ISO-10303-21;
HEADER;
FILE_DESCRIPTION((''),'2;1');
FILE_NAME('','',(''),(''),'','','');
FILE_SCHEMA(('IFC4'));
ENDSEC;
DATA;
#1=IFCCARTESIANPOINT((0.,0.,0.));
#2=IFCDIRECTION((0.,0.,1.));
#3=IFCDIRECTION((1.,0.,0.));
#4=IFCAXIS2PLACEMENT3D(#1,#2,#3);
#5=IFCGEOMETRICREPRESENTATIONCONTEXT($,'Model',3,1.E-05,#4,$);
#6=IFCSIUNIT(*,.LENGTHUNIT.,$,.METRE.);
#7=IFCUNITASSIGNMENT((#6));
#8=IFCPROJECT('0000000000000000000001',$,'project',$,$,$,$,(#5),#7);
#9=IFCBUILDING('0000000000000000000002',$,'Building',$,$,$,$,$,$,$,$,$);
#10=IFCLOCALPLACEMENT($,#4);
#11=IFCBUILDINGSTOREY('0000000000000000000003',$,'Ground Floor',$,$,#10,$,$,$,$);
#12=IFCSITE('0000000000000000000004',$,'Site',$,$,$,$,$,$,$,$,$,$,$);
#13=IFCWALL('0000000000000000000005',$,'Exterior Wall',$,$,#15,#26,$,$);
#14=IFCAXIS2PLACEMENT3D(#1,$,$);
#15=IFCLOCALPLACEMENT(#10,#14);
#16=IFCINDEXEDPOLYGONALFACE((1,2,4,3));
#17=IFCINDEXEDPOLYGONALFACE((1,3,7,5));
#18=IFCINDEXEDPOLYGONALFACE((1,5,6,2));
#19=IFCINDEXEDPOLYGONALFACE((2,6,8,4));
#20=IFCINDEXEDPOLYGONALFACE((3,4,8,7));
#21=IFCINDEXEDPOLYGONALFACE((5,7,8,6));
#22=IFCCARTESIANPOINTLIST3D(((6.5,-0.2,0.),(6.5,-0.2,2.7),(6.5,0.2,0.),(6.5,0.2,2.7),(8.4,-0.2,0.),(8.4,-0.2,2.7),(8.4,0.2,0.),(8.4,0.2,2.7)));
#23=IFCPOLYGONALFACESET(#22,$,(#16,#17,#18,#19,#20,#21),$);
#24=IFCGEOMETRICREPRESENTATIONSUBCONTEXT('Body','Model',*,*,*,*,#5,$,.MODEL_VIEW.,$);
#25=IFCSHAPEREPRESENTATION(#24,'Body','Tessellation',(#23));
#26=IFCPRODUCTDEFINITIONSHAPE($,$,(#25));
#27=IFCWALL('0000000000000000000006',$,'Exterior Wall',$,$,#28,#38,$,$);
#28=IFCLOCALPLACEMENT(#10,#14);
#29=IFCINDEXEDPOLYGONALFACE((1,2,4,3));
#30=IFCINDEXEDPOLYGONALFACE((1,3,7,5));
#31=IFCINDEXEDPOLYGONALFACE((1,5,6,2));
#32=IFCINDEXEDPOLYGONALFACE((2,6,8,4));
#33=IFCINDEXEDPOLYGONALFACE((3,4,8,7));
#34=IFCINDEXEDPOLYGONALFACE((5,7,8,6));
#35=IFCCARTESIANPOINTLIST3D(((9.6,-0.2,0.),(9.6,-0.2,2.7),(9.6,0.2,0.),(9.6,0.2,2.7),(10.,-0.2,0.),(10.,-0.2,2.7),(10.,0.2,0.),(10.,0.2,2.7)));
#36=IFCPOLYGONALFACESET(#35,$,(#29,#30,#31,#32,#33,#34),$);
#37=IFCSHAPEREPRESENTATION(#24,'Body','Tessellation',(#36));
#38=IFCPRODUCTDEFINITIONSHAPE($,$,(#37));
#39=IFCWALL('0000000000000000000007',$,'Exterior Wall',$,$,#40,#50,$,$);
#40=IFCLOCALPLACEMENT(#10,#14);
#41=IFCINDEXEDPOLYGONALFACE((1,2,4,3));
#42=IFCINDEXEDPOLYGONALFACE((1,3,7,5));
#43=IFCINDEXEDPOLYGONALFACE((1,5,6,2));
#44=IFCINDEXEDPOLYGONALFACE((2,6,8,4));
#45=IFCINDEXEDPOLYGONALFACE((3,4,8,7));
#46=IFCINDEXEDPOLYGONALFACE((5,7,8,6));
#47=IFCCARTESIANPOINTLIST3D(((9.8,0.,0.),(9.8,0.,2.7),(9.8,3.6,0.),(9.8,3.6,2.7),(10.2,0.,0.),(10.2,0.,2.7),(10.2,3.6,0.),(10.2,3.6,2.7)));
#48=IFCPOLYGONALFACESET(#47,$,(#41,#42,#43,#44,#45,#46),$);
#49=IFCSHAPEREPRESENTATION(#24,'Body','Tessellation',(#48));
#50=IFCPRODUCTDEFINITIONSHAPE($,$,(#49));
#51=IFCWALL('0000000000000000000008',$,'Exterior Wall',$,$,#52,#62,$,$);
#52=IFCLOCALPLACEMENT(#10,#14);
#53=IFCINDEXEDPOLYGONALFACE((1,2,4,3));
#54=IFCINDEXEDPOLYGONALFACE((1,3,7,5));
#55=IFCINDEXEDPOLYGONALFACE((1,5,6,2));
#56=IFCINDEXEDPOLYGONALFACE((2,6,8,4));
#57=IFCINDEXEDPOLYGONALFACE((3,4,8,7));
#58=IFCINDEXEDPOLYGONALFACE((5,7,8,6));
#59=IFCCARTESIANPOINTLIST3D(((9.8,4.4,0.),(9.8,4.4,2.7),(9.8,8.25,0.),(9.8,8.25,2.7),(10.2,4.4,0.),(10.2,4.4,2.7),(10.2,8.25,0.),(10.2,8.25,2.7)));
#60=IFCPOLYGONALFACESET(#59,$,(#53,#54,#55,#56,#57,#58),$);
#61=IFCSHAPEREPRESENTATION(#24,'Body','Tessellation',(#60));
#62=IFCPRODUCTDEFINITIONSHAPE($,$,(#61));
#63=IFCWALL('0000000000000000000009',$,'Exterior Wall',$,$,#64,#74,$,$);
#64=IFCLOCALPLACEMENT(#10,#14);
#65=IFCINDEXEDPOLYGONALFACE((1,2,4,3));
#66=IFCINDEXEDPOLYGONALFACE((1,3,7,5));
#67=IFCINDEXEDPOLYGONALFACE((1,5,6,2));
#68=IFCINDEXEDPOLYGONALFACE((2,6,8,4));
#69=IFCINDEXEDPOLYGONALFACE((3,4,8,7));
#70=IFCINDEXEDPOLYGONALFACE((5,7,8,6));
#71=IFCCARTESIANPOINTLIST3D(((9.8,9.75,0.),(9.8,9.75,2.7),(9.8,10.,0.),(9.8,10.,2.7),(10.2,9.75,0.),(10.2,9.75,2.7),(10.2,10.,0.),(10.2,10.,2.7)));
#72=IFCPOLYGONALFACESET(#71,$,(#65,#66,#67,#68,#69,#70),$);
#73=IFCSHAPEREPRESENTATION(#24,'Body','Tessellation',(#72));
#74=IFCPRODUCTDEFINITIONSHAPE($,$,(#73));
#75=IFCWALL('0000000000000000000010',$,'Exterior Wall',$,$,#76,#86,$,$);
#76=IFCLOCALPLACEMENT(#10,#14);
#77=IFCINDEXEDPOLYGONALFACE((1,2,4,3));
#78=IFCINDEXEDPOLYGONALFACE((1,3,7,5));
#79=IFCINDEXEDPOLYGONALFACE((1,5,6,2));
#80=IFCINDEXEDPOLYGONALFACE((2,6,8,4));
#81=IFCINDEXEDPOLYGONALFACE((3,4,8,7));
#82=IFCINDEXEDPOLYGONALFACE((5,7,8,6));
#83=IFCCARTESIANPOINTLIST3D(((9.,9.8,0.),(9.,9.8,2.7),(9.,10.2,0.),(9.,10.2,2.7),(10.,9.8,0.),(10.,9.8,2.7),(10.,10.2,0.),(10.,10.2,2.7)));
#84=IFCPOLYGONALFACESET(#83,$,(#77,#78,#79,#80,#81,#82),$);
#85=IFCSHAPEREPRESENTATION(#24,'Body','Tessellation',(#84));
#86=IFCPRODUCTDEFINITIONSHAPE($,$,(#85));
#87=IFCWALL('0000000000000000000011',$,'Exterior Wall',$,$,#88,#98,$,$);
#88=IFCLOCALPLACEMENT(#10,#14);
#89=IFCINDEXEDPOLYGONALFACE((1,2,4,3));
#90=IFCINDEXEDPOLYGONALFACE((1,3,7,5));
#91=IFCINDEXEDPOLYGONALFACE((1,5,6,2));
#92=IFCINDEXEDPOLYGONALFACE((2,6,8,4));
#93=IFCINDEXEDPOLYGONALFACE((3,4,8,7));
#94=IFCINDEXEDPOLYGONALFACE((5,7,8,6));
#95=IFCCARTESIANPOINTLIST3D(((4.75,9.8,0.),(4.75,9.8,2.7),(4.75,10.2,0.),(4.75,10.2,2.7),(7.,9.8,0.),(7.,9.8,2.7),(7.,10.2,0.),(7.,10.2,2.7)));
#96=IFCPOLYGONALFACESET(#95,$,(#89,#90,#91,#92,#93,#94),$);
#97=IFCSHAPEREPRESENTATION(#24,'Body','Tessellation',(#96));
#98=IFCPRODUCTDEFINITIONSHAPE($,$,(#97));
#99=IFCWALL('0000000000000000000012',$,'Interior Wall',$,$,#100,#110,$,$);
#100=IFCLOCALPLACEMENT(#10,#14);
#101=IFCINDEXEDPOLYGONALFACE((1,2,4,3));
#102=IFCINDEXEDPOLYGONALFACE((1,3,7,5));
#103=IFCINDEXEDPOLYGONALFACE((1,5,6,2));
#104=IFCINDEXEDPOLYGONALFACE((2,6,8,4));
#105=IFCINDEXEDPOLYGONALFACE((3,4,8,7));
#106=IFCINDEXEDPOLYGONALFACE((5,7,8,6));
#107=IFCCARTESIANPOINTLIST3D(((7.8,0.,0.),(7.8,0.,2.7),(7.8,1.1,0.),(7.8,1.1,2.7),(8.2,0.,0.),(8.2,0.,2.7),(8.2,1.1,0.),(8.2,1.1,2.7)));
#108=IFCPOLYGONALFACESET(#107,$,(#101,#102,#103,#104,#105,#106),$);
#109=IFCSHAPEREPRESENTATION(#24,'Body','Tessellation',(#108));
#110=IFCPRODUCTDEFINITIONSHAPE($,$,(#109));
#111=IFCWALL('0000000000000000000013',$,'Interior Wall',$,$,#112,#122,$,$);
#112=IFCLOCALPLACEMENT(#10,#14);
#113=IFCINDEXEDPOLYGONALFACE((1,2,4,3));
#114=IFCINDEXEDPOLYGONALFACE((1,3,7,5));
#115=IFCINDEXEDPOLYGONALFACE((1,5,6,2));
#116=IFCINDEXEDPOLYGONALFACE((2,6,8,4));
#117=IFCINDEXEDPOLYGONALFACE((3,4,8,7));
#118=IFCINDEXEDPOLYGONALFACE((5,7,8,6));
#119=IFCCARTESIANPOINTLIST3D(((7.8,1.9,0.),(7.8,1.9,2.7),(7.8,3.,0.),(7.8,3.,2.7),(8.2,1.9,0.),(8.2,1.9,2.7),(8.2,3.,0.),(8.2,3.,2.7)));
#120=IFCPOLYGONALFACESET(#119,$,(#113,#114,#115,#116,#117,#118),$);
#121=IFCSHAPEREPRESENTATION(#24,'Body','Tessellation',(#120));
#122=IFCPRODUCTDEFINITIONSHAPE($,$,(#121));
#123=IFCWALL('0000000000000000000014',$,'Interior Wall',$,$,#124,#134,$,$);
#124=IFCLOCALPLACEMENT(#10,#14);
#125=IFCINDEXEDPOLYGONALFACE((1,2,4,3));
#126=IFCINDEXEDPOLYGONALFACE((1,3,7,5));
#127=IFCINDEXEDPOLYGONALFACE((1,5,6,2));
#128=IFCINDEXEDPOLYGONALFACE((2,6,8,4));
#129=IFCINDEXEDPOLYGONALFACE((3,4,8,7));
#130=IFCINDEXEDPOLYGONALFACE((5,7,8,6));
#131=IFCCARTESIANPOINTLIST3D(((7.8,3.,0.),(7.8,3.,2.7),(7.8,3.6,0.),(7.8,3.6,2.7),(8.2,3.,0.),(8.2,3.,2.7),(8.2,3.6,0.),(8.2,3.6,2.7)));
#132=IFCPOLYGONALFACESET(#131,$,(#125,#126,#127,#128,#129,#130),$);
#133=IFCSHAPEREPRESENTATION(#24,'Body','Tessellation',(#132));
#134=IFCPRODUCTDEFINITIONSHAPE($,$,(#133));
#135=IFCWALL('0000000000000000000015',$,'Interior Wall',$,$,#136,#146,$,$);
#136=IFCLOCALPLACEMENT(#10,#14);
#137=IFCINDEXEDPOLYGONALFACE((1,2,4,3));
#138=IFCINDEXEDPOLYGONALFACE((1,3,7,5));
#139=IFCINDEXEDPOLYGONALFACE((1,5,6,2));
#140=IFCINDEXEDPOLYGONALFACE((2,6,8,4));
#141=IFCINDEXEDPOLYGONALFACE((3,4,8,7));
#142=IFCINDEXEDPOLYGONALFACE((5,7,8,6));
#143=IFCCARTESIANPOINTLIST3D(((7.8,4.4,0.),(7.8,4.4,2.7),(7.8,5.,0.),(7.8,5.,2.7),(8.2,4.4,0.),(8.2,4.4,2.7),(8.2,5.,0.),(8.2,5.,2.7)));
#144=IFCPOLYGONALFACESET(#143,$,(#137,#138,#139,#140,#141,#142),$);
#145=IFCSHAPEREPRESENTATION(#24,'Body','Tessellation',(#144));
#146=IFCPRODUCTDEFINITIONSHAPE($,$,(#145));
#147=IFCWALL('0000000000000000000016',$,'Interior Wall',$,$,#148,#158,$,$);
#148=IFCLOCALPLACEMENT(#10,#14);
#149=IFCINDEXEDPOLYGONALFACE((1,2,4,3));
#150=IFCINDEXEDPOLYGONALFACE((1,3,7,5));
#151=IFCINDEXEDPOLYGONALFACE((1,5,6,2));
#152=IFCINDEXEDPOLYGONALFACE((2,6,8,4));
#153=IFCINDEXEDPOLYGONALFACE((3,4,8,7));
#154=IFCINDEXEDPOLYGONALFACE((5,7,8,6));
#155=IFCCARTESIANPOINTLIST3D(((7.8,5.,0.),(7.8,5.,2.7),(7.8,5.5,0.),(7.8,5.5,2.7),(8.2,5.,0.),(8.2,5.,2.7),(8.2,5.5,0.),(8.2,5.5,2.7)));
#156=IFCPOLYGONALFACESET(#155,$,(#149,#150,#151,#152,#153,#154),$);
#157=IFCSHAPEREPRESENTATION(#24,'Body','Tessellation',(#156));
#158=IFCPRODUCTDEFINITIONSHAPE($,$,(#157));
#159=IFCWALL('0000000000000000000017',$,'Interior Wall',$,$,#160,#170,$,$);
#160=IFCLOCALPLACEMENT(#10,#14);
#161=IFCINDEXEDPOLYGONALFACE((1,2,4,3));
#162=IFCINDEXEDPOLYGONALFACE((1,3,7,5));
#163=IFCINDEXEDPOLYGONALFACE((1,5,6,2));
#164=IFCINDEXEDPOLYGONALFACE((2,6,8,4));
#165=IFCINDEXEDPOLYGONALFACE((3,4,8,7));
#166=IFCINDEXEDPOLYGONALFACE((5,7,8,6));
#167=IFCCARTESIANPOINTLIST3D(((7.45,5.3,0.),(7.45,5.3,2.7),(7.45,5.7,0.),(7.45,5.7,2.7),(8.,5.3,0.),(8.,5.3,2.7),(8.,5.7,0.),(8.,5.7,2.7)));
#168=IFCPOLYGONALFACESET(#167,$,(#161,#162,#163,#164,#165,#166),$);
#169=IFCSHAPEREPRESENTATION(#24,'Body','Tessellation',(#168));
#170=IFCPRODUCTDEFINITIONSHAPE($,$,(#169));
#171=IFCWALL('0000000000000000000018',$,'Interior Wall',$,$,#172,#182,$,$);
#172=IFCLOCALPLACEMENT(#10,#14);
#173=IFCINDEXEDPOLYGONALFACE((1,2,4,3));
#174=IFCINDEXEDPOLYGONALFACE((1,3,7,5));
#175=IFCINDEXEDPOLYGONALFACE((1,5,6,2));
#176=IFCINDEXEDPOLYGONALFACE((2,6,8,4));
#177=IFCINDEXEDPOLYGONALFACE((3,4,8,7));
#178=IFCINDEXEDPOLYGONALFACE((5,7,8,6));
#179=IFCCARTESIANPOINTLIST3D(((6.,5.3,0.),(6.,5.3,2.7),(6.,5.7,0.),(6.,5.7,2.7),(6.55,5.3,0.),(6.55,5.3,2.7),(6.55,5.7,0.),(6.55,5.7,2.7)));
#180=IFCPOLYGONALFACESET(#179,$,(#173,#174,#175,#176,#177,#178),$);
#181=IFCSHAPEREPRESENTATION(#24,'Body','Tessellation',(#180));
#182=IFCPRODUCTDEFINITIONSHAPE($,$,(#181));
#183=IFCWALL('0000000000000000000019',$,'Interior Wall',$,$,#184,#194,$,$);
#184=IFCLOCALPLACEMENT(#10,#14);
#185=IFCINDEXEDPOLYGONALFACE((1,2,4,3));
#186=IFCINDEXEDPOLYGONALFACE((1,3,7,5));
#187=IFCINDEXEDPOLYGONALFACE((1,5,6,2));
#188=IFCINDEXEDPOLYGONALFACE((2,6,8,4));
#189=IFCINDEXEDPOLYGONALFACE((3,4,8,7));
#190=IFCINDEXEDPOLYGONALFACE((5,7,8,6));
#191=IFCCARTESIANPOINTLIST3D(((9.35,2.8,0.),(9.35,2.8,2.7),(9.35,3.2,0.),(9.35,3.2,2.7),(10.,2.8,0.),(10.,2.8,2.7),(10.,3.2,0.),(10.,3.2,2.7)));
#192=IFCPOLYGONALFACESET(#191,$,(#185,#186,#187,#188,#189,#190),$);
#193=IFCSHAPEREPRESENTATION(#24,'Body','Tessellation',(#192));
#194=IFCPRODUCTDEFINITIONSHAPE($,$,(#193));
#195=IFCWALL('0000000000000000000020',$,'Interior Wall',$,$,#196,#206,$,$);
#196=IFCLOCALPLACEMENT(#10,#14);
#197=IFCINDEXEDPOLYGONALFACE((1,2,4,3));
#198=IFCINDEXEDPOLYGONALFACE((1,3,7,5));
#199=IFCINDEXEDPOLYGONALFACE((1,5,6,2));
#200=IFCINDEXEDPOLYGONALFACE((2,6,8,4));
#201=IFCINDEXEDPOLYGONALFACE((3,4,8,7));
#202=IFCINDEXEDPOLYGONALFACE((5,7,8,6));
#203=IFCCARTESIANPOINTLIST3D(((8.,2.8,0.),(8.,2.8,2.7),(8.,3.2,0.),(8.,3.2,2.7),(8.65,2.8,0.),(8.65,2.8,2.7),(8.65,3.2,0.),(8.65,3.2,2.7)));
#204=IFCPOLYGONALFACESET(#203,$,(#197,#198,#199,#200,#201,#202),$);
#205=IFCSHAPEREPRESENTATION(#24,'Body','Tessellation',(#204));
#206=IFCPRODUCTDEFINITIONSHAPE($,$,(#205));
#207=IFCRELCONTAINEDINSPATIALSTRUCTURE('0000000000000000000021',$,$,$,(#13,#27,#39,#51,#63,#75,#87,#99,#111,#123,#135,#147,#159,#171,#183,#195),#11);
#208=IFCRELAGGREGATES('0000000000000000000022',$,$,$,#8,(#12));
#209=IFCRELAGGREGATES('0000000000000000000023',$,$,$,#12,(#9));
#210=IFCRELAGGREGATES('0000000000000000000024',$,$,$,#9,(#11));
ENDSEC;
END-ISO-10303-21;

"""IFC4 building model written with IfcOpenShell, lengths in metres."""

from ifc_helpers import new_model, si_unit, frame, origin_with_axes, place, context, subcontext, project, spatial, indexed_curve, outline, extrude, element, save


model = new_model("IFC4")

# Units and contexts
model_context = context("Model", 3, precision=1e-05, world=origin_with_axes())
body_context = subcontext(model_context, "Body", "Model", "MODEL_VIEW")
ifc_project = project(units=[si_unit("LENGTHUNIT", "METRE")], contexts=[model_context])

# Site, building, storey
site = spatial("IfcSite", under=ifc_project, Name="Site")
building = spatial("IfcBuilding", under=site, Name="Building")
storey_placement = place(None, origin_with_axes())
storey = spatial("IfcBuildingStorey", under=building, at=storey_placement, Name="Ground Floor")

# Walls
wall_1_placement = place(storey_placement, frame((6.5, 0.0, 0.0), z_axis=(0.0, 0.0, 1.0), x_axis=(1.0, 0.0, 0.0)))
element("IfcWall", 1, at=wall_1_placement, inside=storey, Name="Exterior Wall", context=body_context, shape_type="SweptSolid", body=[
    extrude(outline(indexed_curve([(0.0, 0.0), (0.0, 0.4), (1.9, 0.4), (1.9, 0.0), (0.0, 0.0)], self_intersect=False)), frame((0.0, -0.2, 0.0), z_axis=(0.0, 0.0, 1.0), x_axis=(1.0, 0.0, 0.0)), (0.0, 0.0, 1.0), 2.7),
])
wall_2_placement = place(storey_placement, frame((9.6, 0.0, 0.0), z_axis=(0.0, 0.0, 1.0), x_axis=(1.0, 0.0, 0.0)))
element("IfcWall", 2, at=wall_2_placement, inside=storey, Name="Exterior Wall", context=body_context, shape_type="SweptSolid", body=[
    extrude(outline(indexed_curve([(0.0, 0.0), (0.0, 0.4), (0.4, 0.4), (0.4, 0.0), (0.0, 0.0)], self_intersect=False)), frame((0.0, -0.2, 0.0), z_axis=(0.0, 0.0, 1.0), x_axis=(1.0, 0.0, 0.0)), (0.0, 0.0, 1.0), 2.7),
])
wall_3_placement = place(storey_placement, frame((10.0, 0.0, 0.0), z_axis=(0.0, 0.0, 1.0), x_axis=(0.0, 1.0, 0.0)))
element("IfcWall", 3, at=wall_3_placement, inside=storey, Name="Exterior Wall", context=body_context, shape_type="SweptSolid", body=[
    extrude(outline(indexed_curve([(0.0, 0.0), (0.0, 0.4), (3.6, 0.4), (3.6, 0.0), (0.0, 0.0)], self_intersect=False)), frame((0.0, -0.2, 0.0), z_axis=(0.0, 0.0, 1.0), x_axis=(1.0, 0.0, 0.0)), (0.0, 0.0, 1.0), 2.7),
])
wall_4_placement = place(storey_placement, frame((10.0, 4.4, 0.0), z_axis=(0.0, 0.0, 1.0), x_axis=(0.0, 1.0, 0.0)))
element("IfcWall", 4, at=wall_4_placement, inside=storey, Name="Exterior Wall", context=body_context, shape_type="SweptSolid", body=[
    extrude(outline(indexed_curve([(0.0, 0.0), (0.0, 0.4), (3.85, 0.4), (3.85, 0.0), (0.0, 0.0)], self_intersect=False)), frame((0.0, -0.2, 0.0), z_axis=(0.0, 0.0, 1.0), x_axis=(1.0, 0.0, 0.0)), (0.0, 0.0, 1.0), 2.7),
])
wall_5_placement = place(storey_placement, frame((10.0, 9.75, 0.0), z_axis=(0.0, 0.0, 1.0), x_axis=(0.0, 1.0, 0.0)))
element("IfcWall", 5, at=wall_5_placement, inside=storey, Name="Exterior Wall", context=body_context, shape_type="SweptSolid", body=[
    extrude(outline(indexed_curve([(0.0, 0.0), (0.0, 0.4), (0.25, 0.4), (0.25, 0.0), (0.0, 0.0)], self_intersect=False)), frame((0.0, -0.2, 0.0), z_axis=(0.0, 0.0, 1.0), x_axis=(1.0, 0.0, 0.0)), (0.0, 0.0, 1.0), 2.7),
])
wall_6_placement = place(storey_placement, frame((10.0, 10.0, 0.0), z_axis=(0.0, 0.0, 1.0), x_axis=(-1.0, 0.0, 0.0)))
element("IfcWall", 6, at=wall_6_placement, inside=storey, Name="Exterior Wall", context=body_context, shape_type="SweptSolid", body=[
    extrude(outline(indexed_curve([(0.0, 0.0), (0.0, 0.4), (1.0, 0.4), (1.0, 0.0), (0.0, 0.0)], self_intersect=False)), frame((0.0, -0.2, 0.0), z_axis=(0.0, 0.0, 1.0), x_axis=(1.0, 0.0, 0.0)), (0.0, 0.0, 1.0), 2.7),
])
wall_7_placement = place(storey_placement, frame((7.0, 10.0, 0.0), z_axis=(0.0, 0.0, 1.0), x_axis=(-1.0, 0.0, 0.0)))
element("IfcWall", 7, at=wall_7_placement, inside=storey, Name="Exterior Wall", context=body_context, shape_type="SweptSolid", body=[
    extrude(outline(indexed_curve([(0.0, 0.0), (0.0, 0.4), (2.25, 0.4), (2.25, 0.0), (0.0, 0.0)], self_intersect=False)), frame((0.0, -0.2, 0.0), z_axis=(0.0, 0.0, 1.0), x_axis=(1.0, 0.0, 0.0)), (0.0, 0.0, 1.0), 2.7),
])
for number, where, z_axis, x_axis, name in (
    (8, (8.0, 0.0, 0.0), (0.0, 0.0, 1.0), (0.0, 1.0, 0.0), "Interior Wall"),
    (9, (8.0, 1.9, 0.0), (0.0, 0.0, 1.0), (0.0, 1.0, 0.0), "Interior Wall"),
):
    element("IfcWall", number, at=place(storey_placement, frame(where, z_axis=z_axis, x_axis=x_axis)), inside=storey, Name=name, context=body_context, shape_type="SweptSolid", body=[
        extrude(outline(indexed_curve([(0.0, 0.0), (0.0, 0.4), (1.1, 0.4), (1.1, 0.0), (0.0, 0.0)], self_intersect=False)), frame((0.0, -0.2, 0.0), z_axis=(0.0, 0.0, 1.0), x_axis=(1.0, 0.0, 0.0)), (0.0, 0.0, 1.0), 2.7),
    ])
wall_8_placement = place(storey_placement, frame((8.0, 3.0, 0.0), z_axis=(0.0, 0.0, 1.0), x_axis=(0.0, 1.0, 0.0)))
element("IfcWall", 10, at=wall_8_placement, inside=storey, Name="Interior Wall", context=body_context, shape_type="SweptSolid", body=[
    extrude(outline(indexed_curve([(0.0, 0.0), (0.0, 0.4), (0.6, 0.4), (0.6, 0.0), (0.0, 0.0)], self_intersect=False)), frame((0.0, -0.2, 0.0), z_axis=(0.0, 0.0, 1.0), x_axis=(1.0, 0.0, 0.0)), (0.0, 0.0, 1.0), 2.7),
])
wall_9_placement = place(storey_placement, frame((8.0, 4.4, 0.0), z_axis=(0.0, 0.0, 1.0), x_axis=(0.0, 1.0, 0.0)))
element("IfcWall", 11, at=wall_9_placement, inside=storey, Name="Interior Wall", context=body_context, shape_type="SweptSolid", body=[
    extrude(outline(indexed_curve([(0.0, 0.0), (0.0, 0.4), (0.6, 0.4), (0.6, 0.0), (0.0, 0.0)], self_intersect=False)), frame((0.0, -0.2, 0.0), z_axis=(0.0, 0.0, 1.0), x_axis=(1.0, 0.0, 0.0)), (0.0, 0.0, 1.0), 2.7),
])
wall_10_placement = place(storey_placement, frame((8.0, 5.0, 0.0), z_axis=(0.0, 0.0, 1.0), x_axis=(0.0, 1.0, 0.0)))
element("IfcWall", 12, at=wall_10_placement, inside=storey, Name="Interior Wall", context=body_context, shape_type="SweptSolid", body=[
    extrude(outline(indexed_curve([(0.0, 0.0), (0.0, 0.4), (0.5, 0.4), (0.5, 0.0), (0.0, 0.0)], self_intersect=False)), frame((0.0, -0.2, 0.0), z_axis=(0.0, 0.0, 1.0), x_axis=(1.0, 0.0, 0.0)), (0.0, 0.0, 1.0), 2.7),
])
for number, where, z_axis, x_axis, name in (
    (13, (8.0, 5.5, 0.0), (0.0, 0.0, 1.0), (-1.0, 0.0, 0.0), "Interior Wall"),
    (14, (6.55, 5.5, 0.0), (0.0, 0.0, 1.0), (-1.0, 0.0, 0.0), "Interior Wall"),
):
    element("IfcWall", number, at=place(storey_placement, frame(where, z_axis=z_axis, x_axis=x_axis)), inside=storey, Name=name, context=body_context, shape_type="SweptSolid", body=[
        extrude(outline(indexed_curve([(0.0, 0.0), (0.0, 0.4), (0.55, 0.4), (0.55, 0.0), (0.0, 0.0)], self_intersect=False)), frame((0.0, -0.2, 0.0), z_axis=(0.0, 0.0, 1.0), x_axis=(1.0, 0.0, 0.0)), (0.0, 0.0, 1.0), 2.7),
    ])
for number, where, z_axis, x_axis, name in (
    (15, (10.0, 3.0, 0.0), (0.0, 0.0, 1.0), (-1.0, 0.0, 0.0), "Interior Wall"),
    (16, (8.65, 3.0, 0.0), (0.0, 0.0, 1.0), (-1.0, 0.0, 0.0), "Interior Wall"),
):
    element("IfcWall", number, at=place(storey_placement, frame(where, z_axis=z_axis, x_axis=x_axis)), inside=storey, Name=name, context=body_context, shape_type="SweptSolid", body=[
        extrude(outline(indexed_curve([(0.0, 0.0), (0.0, 0.4), (0.65, 0.4), (0.65, 0.0), (0.0, 0.0)], self_intersect=False)), frame((0.0, -0.2, 0.0), z_axis=(0.0, 0.0, 1.0), x_axis=(1.0, 0.0, 0.0)), (0.0, 0.0, 1.0), 2.7),
    ])

save(model, "model.ifc")
